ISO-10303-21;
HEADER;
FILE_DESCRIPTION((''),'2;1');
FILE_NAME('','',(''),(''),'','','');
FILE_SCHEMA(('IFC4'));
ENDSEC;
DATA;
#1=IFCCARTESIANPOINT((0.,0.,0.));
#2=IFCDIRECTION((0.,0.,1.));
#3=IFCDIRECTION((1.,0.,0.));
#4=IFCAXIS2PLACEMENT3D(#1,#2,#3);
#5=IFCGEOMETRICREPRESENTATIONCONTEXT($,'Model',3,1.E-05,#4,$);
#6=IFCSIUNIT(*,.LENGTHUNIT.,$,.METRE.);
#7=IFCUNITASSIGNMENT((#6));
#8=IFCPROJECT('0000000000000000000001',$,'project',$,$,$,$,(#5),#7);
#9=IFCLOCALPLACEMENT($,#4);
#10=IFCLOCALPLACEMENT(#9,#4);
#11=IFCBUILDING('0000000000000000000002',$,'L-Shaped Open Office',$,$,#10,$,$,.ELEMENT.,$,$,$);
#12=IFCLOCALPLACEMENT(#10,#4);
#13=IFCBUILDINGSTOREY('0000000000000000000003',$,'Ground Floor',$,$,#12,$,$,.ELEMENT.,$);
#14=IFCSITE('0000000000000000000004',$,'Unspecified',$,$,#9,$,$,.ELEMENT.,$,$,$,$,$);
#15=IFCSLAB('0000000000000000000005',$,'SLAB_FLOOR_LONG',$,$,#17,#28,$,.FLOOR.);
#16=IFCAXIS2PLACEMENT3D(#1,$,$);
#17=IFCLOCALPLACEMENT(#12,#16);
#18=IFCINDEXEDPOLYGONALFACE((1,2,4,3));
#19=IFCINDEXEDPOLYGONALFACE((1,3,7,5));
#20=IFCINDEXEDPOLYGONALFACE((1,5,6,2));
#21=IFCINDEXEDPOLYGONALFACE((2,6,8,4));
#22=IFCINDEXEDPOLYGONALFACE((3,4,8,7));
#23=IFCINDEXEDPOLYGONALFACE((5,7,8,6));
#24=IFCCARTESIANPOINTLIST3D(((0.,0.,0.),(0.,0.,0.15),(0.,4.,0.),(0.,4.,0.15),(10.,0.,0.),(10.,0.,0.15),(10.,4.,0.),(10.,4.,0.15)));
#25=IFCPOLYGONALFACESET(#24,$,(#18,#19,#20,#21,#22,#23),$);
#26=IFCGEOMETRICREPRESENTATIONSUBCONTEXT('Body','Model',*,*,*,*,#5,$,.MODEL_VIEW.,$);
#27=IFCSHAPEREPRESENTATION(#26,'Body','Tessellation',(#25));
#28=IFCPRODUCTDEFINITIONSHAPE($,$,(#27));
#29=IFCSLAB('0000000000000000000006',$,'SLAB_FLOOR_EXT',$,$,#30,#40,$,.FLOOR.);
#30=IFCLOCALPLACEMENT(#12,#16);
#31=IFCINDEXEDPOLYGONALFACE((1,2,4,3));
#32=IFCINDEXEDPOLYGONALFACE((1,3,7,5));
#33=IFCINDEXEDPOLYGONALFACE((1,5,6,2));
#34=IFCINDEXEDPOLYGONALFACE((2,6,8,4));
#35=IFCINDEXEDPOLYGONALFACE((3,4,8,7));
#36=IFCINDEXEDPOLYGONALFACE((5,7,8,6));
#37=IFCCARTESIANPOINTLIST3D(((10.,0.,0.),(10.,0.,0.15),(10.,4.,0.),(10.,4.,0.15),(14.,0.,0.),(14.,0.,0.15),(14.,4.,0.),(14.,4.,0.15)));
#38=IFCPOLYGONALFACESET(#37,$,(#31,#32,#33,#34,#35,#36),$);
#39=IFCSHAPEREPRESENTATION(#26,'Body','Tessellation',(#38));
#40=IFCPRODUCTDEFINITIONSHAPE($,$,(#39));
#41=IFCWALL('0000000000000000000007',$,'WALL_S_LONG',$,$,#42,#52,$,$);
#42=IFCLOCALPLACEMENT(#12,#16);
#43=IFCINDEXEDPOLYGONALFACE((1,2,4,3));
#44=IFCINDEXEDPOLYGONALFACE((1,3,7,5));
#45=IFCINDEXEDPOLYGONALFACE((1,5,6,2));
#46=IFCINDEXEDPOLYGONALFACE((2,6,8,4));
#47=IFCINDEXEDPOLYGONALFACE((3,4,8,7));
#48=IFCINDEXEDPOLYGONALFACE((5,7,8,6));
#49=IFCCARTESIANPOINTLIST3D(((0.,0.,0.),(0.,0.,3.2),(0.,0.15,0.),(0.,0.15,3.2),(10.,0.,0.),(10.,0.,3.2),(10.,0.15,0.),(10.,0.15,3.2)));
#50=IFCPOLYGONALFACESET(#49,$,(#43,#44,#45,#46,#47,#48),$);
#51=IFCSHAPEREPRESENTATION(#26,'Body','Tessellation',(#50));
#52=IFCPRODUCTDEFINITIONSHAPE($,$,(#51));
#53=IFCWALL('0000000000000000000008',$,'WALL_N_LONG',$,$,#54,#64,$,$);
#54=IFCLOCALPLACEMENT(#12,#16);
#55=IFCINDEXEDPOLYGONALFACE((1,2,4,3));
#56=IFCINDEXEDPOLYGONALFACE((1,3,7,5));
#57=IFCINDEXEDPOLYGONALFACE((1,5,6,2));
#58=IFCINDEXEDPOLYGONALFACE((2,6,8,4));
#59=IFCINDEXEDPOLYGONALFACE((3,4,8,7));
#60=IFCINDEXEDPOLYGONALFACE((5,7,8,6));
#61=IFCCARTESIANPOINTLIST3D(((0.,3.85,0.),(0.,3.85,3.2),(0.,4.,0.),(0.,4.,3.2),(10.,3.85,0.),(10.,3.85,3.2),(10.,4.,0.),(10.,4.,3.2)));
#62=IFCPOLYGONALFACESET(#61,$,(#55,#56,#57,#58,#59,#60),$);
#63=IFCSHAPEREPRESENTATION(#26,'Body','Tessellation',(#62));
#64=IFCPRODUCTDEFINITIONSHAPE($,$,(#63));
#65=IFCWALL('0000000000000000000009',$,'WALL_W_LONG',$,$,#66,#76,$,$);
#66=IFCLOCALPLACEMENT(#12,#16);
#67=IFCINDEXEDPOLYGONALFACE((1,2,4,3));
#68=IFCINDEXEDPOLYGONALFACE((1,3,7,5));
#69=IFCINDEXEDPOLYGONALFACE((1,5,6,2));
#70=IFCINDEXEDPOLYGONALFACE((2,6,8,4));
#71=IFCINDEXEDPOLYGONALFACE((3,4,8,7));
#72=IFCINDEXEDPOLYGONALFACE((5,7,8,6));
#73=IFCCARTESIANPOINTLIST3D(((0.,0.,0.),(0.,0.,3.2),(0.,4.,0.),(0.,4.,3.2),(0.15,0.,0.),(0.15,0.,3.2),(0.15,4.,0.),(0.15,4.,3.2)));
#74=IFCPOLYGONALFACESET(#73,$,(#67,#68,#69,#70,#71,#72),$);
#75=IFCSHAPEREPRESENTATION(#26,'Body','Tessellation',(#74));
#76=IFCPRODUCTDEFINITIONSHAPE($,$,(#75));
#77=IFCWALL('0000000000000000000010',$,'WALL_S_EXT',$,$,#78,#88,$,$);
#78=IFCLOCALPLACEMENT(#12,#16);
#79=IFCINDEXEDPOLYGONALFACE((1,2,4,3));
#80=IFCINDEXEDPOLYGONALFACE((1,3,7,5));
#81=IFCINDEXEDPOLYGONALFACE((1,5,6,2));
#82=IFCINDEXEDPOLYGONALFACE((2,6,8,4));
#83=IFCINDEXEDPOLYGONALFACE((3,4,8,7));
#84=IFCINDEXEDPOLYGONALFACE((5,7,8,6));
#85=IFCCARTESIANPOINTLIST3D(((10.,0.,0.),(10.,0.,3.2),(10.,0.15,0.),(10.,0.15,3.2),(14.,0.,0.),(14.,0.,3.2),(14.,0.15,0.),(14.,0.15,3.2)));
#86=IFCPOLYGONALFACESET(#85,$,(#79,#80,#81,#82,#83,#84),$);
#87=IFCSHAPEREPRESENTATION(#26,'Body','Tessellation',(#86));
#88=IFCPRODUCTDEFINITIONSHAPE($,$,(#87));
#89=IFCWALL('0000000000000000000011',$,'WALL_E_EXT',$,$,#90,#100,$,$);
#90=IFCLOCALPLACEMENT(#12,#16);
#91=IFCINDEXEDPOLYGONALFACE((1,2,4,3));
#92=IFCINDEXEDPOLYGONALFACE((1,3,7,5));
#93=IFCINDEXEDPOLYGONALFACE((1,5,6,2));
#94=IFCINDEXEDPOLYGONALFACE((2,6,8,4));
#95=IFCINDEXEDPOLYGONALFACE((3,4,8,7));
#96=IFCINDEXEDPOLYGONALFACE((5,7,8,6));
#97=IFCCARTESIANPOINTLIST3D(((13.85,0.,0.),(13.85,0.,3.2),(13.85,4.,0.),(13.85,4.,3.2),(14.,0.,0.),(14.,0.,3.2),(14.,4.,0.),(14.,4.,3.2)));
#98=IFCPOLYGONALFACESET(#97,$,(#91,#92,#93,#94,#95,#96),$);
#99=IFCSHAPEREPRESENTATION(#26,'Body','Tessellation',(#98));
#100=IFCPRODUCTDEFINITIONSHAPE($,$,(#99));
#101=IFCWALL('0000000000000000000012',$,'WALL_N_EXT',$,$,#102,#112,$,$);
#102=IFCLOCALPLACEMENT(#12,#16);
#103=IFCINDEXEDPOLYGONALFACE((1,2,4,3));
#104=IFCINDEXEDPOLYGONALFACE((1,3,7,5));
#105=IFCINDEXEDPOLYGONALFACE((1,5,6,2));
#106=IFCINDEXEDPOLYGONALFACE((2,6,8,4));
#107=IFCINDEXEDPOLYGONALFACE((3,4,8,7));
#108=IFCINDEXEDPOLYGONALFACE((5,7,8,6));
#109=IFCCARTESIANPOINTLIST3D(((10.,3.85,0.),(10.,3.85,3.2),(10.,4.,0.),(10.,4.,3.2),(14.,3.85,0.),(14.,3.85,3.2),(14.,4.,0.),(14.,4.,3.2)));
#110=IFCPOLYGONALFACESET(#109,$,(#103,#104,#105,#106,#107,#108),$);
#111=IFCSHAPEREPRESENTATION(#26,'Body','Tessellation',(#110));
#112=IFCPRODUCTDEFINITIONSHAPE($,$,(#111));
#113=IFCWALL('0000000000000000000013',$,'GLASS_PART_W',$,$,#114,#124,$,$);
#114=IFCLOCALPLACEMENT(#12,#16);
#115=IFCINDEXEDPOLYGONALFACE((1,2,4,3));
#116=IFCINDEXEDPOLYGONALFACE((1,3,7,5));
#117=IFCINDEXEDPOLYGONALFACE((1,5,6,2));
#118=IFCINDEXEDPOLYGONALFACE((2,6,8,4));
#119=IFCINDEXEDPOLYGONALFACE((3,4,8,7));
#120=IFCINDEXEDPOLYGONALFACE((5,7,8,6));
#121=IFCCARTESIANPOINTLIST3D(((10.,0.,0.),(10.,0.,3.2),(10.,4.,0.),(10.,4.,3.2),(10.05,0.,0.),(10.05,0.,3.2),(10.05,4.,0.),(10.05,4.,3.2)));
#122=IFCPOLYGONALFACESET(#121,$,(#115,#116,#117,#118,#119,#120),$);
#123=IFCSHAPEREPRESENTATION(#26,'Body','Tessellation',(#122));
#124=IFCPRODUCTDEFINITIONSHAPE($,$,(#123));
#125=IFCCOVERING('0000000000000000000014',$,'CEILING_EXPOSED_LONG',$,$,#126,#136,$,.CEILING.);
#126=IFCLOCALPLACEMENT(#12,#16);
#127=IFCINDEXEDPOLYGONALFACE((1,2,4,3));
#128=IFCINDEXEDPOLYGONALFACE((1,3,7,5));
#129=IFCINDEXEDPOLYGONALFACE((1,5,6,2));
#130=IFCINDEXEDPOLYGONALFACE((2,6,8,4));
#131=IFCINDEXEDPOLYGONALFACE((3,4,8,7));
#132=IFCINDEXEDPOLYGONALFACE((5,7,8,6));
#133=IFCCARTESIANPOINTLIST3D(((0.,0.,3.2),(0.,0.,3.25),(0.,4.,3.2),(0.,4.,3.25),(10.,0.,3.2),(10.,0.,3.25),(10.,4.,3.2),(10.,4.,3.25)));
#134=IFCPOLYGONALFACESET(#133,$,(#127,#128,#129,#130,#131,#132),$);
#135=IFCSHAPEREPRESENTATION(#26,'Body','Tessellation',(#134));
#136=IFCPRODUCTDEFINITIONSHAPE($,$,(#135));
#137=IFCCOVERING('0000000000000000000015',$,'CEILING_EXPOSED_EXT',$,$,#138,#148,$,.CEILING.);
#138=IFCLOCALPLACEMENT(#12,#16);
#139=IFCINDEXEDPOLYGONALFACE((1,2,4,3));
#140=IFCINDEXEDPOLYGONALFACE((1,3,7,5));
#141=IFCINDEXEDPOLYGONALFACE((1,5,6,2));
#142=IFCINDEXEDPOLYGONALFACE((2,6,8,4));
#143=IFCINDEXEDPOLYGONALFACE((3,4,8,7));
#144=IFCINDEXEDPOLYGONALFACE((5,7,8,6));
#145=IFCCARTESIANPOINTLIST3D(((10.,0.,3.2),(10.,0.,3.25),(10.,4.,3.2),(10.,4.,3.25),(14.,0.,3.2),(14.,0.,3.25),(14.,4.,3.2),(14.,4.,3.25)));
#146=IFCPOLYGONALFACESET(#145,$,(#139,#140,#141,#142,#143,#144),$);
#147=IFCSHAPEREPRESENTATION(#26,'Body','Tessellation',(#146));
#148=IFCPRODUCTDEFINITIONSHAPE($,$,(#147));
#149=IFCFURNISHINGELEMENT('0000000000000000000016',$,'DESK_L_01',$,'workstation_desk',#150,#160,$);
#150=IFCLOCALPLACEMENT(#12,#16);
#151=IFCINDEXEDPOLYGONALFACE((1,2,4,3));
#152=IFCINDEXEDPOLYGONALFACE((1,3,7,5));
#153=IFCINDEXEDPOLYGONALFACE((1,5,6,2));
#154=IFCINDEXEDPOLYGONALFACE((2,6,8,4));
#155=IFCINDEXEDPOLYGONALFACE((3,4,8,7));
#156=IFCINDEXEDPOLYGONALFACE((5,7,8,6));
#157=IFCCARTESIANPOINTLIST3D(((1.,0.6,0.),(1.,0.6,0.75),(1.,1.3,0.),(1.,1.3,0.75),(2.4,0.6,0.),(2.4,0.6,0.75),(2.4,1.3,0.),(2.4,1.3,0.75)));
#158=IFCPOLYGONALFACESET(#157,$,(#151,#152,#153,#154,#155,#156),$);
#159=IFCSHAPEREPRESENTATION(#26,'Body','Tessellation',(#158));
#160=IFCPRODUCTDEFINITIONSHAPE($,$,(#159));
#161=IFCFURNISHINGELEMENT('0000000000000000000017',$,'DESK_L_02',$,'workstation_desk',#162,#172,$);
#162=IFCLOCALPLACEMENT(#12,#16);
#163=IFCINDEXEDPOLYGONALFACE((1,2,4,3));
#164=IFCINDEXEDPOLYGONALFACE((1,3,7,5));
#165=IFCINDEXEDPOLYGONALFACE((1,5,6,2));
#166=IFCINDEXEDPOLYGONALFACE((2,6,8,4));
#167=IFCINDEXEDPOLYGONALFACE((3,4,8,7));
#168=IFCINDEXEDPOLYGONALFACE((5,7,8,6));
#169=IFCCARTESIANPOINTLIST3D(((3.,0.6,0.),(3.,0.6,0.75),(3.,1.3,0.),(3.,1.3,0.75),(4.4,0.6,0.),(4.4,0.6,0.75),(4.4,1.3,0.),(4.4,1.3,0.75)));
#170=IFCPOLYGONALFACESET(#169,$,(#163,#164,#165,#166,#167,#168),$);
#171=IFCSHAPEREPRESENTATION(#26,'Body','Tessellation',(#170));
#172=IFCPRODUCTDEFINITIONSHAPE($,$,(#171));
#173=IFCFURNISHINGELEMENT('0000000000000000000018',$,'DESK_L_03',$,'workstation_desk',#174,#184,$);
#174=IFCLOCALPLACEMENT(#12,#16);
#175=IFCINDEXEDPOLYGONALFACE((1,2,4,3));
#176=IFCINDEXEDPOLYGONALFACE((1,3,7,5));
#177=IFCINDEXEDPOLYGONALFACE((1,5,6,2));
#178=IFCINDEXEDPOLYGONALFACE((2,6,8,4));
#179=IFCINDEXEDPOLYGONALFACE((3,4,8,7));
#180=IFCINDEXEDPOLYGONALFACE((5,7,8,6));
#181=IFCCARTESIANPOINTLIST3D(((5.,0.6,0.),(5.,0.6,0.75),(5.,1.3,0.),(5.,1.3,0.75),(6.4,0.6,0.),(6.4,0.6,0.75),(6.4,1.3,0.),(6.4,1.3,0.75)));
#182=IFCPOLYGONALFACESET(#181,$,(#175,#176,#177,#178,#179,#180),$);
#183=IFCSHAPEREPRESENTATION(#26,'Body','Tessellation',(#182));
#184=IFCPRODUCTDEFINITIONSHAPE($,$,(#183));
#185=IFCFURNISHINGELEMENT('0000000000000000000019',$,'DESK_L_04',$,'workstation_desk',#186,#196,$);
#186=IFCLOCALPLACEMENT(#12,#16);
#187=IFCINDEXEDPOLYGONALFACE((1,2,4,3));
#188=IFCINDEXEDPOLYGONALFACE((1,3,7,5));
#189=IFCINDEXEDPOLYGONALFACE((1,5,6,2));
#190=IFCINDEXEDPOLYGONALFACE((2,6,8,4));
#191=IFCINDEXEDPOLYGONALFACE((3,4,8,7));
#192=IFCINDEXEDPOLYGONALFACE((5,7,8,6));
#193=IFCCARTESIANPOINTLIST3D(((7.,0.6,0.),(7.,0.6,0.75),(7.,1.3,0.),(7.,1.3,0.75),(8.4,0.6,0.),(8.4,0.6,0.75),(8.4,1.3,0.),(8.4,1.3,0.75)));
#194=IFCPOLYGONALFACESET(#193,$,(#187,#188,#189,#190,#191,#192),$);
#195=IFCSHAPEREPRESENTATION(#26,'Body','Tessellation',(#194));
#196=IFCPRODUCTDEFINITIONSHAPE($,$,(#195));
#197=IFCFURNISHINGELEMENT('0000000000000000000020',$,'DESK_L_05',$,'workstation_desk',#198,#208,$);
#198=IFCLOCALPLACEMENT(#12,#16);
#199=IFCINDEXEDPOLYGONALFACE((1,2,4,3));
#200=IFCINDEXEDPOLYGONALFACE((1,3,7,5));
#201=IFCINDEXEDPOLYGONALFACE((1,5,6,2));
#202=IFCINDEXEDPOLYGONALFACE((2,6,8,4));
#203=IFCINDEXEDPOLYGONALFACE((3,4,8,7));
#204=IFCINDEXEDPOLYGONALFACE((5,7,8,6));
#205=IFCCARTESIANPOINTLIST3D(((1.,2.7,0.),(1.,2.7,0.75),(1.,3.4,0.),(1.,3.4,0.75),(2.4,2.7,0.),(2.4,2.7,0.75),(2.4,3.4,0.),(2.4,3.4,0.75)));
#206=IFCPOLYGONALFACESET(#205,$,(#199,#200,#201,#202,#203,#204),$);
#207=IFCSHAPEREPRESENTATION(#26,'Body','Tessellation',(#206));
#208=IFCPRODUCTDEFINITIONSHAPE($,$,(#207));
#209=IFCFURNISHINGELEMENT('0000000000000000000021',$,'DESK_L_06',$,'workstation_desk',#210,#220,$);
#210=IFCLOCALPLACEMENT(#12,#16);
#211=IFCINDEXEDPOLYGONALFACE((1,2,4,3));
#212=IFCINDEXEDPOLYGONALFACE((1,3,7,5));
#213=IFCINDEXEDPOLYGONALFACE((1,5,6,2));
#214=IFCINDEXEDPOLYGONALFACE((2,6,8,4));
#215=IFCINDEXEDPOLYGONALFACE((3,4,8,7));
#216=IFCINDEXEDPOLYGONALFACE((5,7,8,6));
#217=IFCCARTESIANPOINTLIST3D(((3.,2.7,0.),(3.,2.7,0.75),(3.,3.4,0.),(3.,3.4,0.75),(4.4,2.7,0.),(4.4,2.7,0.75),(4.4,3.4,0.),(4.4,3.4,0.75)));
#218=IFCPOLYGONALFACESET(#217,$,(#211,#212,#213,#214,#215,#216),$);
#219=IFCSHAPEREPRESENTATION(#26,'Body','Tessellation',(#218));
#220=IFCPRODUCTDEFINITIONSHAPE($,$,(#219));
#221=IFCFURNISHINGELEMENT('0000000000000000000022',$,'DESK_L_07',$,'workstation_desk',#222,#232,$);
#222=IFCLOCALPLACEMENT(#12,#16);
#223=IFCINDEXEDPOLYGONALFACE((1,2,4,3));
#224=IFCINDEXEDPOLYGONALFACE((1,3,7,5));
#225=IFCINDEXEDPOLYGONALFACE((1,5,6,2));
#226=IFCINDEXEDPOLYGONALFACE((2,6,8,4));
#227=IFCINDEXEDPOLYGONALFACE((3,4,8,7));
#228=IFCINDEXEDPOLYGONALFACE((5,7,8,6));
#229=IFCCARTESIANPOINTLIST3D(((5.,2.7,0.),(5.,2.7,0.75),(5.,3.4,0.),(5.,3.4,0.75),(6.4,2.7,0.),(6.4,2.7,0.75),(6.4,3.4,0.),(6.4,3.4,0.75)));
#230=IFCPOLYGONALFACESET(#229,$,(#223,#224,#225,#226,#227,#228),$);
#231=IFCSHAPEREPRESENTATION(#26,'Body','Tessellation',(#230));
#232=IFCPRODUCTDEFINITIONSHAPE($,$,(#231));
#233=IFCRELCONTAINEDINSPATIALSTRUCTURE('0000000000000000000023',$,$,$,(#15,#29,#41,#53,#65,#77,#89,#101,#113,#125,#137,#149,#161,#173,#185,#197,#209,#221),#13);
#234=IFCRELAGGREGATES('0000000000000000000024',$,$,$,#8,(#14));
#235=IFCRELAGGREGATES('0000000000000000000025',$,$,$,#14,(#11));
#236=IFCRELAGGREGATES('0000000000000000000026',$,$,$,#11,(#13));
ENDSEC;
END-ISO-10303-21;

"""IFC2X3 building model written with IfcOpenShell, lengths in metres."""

from ifc_helpers import new_model, si_unit, frame, frame_2d, origin, origin_with_axes, place, context, subcontext, project, spatial, rectangle, extrude, element, save


model = new_model("IFC2X3")

# Units and contexts
model_context = context("Model", 3, precision=1e-05, world=origin_with_axes())
body_context = subcontext(model_context, "Body", "Model", "MODEL_VIEW")
ifc_project = project(units=[si_unit("LENGTHUNIT", "METRE")], contexts=[model_context])

# Site, building, storey
site_placement = place(None, origin_with_axes())
site = spatial("IfcSite", under=ifc_project, at=site_placement, Name="Unspecified", CompositionType="ELEMENT")
building_placement = place(site_placement, origin_with_axes())
building = spatial("IfcBuilding", under=site, at=building_placement, Name="L-Shaped Open Office", CompositionType="ELEMENT")
storey_placement = place(building_placement, origin_with_axes())
storey = spatial("IfcBuildingStorey", under=building, at=storey_placement, Name="Ground Floor", CompositionType="ELEMENT")

# Slabs
slab_1_placement = place(storey_placement, origin_with_axes())
element("IfcSlab", 1, at=slab_1_placement, inside=storey, Name="SLAB_FLOOR_LONG", PredefinedType="FLOOR", context=body_context, shape_type="SweptSolid", body=[
    extrude(rectangle(XDim=10.0, YDim=4.0, at=frame_2d((5.0, 2.0))), origin(), (0.0, 0.0, 1.0), 0.15),
])
slab_2_placement = place(storey_placement, frame((10.0, 0.0, 0.0), z_axis=(0.0, 0.0, 1.0), x_axis=(1.0, 0.0, 0.0)))
element("IfcSlab", 2, at=slab_2_placement, inside=storey, Name="SLAB_FLOOR_EXT", PredefinedType="FLOOR", context=body_context, shape_type="SweptSolid", body=[
    extrude(rectangle(XDim=4.0, YDim=4.0, at=frame_2d((2.0, 2.0))), origin(), (0.0, 0.0, 1.0), 0.15),
])

# Walls
for number, where, z_axis, x_axis, name in (
    (3, (0.0, 0.0, 0.0), (0.0, 0.0, 1.0), (1.0, 0.0, 0.0), "WALL_S_LONG"),
    (4, (0.0, 3.85, 0.0), (0.0, 0.0, 1.0), (1.0, 0.0, 0.0), "WALL_N_LONG"),
):
    element("IfcWall", number, at=place(storey_placement, frame(where, z_axis=z_axis, x_axis=x_axis)), inside=storey, Name=name, context=body_context, shape_type="SweptSolid", body=[
        extrude(rectangle(XDim=10.0, YDim=0.15, at=frame_2d((5.0, 0.075))), origin(), (0.0, 0.0, 1.0), 3.2),
    ])
wall_1_placement = place(storey_placement, origin_with_axes())
element("IfcWall", 5, at=wall_1_placement, inside=storey, Name="WALL_W_LONG", context=body_context, shape_type="SweptSolid", body=[
    extrude(rectangle(XDim=0.15, YDim=4.0, at=frame_2d((0.075, 2.0))), origin(), (0.0, 0.0, 1.0), 3.2),
])
wall_2_placement = place(storey_placement, frame((10.0, 0.0, 0.0), z_axis=(0.0, 0.0, 1.0), x_axis=(1.0, 0.0, 0.0)))
element("IfcWall", 6, at=wall_2_placement, inside=storey, Name="WALL_S_EXT", context=body_context, shape_type="SweptSolid", body=[
    extrude(rectangle(XDim=4.0, YDim=0.15, at=frame_2d((2.0, 0.075))), origin(), (0.0, 0.0, 1.0), 3.2),
])
wall_3_placement = place(storey_placement, frame((13.85, 0.0, 0.0), z_axis=(0.0, 0.0, 1.0), x_axis=(1.0, 0.0, 0.0)))
element("IfcWall", 7, at=wall_3_placement, inside=storey, Name="WALL_E_EXT", context=body_context, shape_type="SweptSolid", body=[
    extrude(rectangle(XDim=0.15, YDim=4.0, at=frame_2d((0.075, 2.0))), origin(), (0.0, 0.0, 1.0), 3.2),
])
wall_4_placement = place(storey_placement, frame((10.0, 3.85, 0.0), z_axis=(0.0, 0.0, 1.0), x_axis=(1.0, 0.0, 0.0)))
element("IfcWall", 8, at=wall_4_placement, inside=storey, Name="WALL_N_EXT", context=body_context, shape_type="SweptSolid", body=[
    extrude(rectangle(XDim=4.0, YDim=0.15, at=frame_2d((2.0, 0.075))), origin(), (0.0, 0.0, 1.0), 3.2),
])
wall_5_placement = place(storey_placement, frame((10.0, 0.0, 0.0), z_axis=(0.0, 0.0, 1.0), x_axis=(1.0, 0.0, 0.0)))
element("IfcWall", 9, at=wall_5_placement, inside=storey, Name="GLASS_PART_W", context=body_context, shape_type="SweptSolid", body=[
    extrude(rectangle(XDim=0.05, YDim=4.0, at=frame_2d((0.025, 2.0))), origin(), (0.0, 0.0, 1.0), 3.2),
])

# Coverings
covering_1_placement = place(storey_placement, frame((0.0, 0.0, 3.2), z_axis=(0.0, 0.0, 1.0), x_axis=(1.0, 0.0, 0.0)))
element("IfcCovering", 10, at=covering_1_placement, inside=storey, Name="CEILING_EXPOSED_LONG", PredefinedType="CEILING", context=body_context, shape_type="SweptSolid", body=[
    extrude(rectangle(XDim=10.0, YDim=4.0, at=frame_2d((5.0, 2.0))), origin(), (0.0, 0.0, 1.0), 0.05),
])
covering_2_placement = place(storey_placement, frame((10.0, 0.0, 3.2), z_axis=(0.0, 0.0, 1.0), x_axis=(1.0, 0.0, 0.0)))
element("IfcCovering", 11, at=covering_2_placement, inside=storey, Name="CEILING_EXPOSED_EXT", PredefinedType="CEILING", context=body_context, shape_type="SweptSolid", body=[
    extrude(rectangle(XDim=4.0, YDim=4.0, at=frame_2d((2.0, 2.0))), origin(), (0.0, 0.0, 1.0), 0.05),
])

# Furnishing elements
for number, where, z_axis, x_axis, name in (
    (12, (1.0, 0.6, 0.0), (0.0, 0.0, 1.0), (1.0, 0.0, 0.0), "DESK_L_01"),
    (13, (3.0, 0.6, 0.0), (0.0, 0.0, 1.0), (1.0, 0.0, 0.0), "DESK_L_02"),
    (14, (5.0, 0.6, 0.0), (0.0, 0.0, 1.0), (1.0, 0.0, 0.0), "DESK_L_03"),
    (15, (7.0, 0.6, 0.0), (0.0, 0.0, 1.0), (1.0, 0.0, 0.0), "DESK_L_04"),
    (16, (1.0, 2.7, 0.0), (0.0, 0.0, 1.0), (1.0, 0.0, 0.0), "DESK_L_05"),
    (17, (3.0, 2.7, 0.0), (0.0, 0.0, 1.0), (1.0, 0.0, 0.0), "DESK_L_06"),
    (18, (5.0, 2.7, 0.0), (0.0, 0.0, 1.0), (1.0, 0.0, 0.0), "DESK_L_07"),
):
    element("IfcFurnishingElement", number, at=place(storey_placement, frame(where, z_axis=z_axis, x_axis=x_axis)), inside=storey, Name=name, ObjectType="workstation_desk", context=body_context, shape_type="SweptSolid", body=[
        extrude(rectangle(XDim=1.4, YDim=0.7, at=frame_2d((0.7, 0.35))), origin(), (0.0, 0.0, 1.0), 0.75),
    ])

save(model, "model.ifc")
